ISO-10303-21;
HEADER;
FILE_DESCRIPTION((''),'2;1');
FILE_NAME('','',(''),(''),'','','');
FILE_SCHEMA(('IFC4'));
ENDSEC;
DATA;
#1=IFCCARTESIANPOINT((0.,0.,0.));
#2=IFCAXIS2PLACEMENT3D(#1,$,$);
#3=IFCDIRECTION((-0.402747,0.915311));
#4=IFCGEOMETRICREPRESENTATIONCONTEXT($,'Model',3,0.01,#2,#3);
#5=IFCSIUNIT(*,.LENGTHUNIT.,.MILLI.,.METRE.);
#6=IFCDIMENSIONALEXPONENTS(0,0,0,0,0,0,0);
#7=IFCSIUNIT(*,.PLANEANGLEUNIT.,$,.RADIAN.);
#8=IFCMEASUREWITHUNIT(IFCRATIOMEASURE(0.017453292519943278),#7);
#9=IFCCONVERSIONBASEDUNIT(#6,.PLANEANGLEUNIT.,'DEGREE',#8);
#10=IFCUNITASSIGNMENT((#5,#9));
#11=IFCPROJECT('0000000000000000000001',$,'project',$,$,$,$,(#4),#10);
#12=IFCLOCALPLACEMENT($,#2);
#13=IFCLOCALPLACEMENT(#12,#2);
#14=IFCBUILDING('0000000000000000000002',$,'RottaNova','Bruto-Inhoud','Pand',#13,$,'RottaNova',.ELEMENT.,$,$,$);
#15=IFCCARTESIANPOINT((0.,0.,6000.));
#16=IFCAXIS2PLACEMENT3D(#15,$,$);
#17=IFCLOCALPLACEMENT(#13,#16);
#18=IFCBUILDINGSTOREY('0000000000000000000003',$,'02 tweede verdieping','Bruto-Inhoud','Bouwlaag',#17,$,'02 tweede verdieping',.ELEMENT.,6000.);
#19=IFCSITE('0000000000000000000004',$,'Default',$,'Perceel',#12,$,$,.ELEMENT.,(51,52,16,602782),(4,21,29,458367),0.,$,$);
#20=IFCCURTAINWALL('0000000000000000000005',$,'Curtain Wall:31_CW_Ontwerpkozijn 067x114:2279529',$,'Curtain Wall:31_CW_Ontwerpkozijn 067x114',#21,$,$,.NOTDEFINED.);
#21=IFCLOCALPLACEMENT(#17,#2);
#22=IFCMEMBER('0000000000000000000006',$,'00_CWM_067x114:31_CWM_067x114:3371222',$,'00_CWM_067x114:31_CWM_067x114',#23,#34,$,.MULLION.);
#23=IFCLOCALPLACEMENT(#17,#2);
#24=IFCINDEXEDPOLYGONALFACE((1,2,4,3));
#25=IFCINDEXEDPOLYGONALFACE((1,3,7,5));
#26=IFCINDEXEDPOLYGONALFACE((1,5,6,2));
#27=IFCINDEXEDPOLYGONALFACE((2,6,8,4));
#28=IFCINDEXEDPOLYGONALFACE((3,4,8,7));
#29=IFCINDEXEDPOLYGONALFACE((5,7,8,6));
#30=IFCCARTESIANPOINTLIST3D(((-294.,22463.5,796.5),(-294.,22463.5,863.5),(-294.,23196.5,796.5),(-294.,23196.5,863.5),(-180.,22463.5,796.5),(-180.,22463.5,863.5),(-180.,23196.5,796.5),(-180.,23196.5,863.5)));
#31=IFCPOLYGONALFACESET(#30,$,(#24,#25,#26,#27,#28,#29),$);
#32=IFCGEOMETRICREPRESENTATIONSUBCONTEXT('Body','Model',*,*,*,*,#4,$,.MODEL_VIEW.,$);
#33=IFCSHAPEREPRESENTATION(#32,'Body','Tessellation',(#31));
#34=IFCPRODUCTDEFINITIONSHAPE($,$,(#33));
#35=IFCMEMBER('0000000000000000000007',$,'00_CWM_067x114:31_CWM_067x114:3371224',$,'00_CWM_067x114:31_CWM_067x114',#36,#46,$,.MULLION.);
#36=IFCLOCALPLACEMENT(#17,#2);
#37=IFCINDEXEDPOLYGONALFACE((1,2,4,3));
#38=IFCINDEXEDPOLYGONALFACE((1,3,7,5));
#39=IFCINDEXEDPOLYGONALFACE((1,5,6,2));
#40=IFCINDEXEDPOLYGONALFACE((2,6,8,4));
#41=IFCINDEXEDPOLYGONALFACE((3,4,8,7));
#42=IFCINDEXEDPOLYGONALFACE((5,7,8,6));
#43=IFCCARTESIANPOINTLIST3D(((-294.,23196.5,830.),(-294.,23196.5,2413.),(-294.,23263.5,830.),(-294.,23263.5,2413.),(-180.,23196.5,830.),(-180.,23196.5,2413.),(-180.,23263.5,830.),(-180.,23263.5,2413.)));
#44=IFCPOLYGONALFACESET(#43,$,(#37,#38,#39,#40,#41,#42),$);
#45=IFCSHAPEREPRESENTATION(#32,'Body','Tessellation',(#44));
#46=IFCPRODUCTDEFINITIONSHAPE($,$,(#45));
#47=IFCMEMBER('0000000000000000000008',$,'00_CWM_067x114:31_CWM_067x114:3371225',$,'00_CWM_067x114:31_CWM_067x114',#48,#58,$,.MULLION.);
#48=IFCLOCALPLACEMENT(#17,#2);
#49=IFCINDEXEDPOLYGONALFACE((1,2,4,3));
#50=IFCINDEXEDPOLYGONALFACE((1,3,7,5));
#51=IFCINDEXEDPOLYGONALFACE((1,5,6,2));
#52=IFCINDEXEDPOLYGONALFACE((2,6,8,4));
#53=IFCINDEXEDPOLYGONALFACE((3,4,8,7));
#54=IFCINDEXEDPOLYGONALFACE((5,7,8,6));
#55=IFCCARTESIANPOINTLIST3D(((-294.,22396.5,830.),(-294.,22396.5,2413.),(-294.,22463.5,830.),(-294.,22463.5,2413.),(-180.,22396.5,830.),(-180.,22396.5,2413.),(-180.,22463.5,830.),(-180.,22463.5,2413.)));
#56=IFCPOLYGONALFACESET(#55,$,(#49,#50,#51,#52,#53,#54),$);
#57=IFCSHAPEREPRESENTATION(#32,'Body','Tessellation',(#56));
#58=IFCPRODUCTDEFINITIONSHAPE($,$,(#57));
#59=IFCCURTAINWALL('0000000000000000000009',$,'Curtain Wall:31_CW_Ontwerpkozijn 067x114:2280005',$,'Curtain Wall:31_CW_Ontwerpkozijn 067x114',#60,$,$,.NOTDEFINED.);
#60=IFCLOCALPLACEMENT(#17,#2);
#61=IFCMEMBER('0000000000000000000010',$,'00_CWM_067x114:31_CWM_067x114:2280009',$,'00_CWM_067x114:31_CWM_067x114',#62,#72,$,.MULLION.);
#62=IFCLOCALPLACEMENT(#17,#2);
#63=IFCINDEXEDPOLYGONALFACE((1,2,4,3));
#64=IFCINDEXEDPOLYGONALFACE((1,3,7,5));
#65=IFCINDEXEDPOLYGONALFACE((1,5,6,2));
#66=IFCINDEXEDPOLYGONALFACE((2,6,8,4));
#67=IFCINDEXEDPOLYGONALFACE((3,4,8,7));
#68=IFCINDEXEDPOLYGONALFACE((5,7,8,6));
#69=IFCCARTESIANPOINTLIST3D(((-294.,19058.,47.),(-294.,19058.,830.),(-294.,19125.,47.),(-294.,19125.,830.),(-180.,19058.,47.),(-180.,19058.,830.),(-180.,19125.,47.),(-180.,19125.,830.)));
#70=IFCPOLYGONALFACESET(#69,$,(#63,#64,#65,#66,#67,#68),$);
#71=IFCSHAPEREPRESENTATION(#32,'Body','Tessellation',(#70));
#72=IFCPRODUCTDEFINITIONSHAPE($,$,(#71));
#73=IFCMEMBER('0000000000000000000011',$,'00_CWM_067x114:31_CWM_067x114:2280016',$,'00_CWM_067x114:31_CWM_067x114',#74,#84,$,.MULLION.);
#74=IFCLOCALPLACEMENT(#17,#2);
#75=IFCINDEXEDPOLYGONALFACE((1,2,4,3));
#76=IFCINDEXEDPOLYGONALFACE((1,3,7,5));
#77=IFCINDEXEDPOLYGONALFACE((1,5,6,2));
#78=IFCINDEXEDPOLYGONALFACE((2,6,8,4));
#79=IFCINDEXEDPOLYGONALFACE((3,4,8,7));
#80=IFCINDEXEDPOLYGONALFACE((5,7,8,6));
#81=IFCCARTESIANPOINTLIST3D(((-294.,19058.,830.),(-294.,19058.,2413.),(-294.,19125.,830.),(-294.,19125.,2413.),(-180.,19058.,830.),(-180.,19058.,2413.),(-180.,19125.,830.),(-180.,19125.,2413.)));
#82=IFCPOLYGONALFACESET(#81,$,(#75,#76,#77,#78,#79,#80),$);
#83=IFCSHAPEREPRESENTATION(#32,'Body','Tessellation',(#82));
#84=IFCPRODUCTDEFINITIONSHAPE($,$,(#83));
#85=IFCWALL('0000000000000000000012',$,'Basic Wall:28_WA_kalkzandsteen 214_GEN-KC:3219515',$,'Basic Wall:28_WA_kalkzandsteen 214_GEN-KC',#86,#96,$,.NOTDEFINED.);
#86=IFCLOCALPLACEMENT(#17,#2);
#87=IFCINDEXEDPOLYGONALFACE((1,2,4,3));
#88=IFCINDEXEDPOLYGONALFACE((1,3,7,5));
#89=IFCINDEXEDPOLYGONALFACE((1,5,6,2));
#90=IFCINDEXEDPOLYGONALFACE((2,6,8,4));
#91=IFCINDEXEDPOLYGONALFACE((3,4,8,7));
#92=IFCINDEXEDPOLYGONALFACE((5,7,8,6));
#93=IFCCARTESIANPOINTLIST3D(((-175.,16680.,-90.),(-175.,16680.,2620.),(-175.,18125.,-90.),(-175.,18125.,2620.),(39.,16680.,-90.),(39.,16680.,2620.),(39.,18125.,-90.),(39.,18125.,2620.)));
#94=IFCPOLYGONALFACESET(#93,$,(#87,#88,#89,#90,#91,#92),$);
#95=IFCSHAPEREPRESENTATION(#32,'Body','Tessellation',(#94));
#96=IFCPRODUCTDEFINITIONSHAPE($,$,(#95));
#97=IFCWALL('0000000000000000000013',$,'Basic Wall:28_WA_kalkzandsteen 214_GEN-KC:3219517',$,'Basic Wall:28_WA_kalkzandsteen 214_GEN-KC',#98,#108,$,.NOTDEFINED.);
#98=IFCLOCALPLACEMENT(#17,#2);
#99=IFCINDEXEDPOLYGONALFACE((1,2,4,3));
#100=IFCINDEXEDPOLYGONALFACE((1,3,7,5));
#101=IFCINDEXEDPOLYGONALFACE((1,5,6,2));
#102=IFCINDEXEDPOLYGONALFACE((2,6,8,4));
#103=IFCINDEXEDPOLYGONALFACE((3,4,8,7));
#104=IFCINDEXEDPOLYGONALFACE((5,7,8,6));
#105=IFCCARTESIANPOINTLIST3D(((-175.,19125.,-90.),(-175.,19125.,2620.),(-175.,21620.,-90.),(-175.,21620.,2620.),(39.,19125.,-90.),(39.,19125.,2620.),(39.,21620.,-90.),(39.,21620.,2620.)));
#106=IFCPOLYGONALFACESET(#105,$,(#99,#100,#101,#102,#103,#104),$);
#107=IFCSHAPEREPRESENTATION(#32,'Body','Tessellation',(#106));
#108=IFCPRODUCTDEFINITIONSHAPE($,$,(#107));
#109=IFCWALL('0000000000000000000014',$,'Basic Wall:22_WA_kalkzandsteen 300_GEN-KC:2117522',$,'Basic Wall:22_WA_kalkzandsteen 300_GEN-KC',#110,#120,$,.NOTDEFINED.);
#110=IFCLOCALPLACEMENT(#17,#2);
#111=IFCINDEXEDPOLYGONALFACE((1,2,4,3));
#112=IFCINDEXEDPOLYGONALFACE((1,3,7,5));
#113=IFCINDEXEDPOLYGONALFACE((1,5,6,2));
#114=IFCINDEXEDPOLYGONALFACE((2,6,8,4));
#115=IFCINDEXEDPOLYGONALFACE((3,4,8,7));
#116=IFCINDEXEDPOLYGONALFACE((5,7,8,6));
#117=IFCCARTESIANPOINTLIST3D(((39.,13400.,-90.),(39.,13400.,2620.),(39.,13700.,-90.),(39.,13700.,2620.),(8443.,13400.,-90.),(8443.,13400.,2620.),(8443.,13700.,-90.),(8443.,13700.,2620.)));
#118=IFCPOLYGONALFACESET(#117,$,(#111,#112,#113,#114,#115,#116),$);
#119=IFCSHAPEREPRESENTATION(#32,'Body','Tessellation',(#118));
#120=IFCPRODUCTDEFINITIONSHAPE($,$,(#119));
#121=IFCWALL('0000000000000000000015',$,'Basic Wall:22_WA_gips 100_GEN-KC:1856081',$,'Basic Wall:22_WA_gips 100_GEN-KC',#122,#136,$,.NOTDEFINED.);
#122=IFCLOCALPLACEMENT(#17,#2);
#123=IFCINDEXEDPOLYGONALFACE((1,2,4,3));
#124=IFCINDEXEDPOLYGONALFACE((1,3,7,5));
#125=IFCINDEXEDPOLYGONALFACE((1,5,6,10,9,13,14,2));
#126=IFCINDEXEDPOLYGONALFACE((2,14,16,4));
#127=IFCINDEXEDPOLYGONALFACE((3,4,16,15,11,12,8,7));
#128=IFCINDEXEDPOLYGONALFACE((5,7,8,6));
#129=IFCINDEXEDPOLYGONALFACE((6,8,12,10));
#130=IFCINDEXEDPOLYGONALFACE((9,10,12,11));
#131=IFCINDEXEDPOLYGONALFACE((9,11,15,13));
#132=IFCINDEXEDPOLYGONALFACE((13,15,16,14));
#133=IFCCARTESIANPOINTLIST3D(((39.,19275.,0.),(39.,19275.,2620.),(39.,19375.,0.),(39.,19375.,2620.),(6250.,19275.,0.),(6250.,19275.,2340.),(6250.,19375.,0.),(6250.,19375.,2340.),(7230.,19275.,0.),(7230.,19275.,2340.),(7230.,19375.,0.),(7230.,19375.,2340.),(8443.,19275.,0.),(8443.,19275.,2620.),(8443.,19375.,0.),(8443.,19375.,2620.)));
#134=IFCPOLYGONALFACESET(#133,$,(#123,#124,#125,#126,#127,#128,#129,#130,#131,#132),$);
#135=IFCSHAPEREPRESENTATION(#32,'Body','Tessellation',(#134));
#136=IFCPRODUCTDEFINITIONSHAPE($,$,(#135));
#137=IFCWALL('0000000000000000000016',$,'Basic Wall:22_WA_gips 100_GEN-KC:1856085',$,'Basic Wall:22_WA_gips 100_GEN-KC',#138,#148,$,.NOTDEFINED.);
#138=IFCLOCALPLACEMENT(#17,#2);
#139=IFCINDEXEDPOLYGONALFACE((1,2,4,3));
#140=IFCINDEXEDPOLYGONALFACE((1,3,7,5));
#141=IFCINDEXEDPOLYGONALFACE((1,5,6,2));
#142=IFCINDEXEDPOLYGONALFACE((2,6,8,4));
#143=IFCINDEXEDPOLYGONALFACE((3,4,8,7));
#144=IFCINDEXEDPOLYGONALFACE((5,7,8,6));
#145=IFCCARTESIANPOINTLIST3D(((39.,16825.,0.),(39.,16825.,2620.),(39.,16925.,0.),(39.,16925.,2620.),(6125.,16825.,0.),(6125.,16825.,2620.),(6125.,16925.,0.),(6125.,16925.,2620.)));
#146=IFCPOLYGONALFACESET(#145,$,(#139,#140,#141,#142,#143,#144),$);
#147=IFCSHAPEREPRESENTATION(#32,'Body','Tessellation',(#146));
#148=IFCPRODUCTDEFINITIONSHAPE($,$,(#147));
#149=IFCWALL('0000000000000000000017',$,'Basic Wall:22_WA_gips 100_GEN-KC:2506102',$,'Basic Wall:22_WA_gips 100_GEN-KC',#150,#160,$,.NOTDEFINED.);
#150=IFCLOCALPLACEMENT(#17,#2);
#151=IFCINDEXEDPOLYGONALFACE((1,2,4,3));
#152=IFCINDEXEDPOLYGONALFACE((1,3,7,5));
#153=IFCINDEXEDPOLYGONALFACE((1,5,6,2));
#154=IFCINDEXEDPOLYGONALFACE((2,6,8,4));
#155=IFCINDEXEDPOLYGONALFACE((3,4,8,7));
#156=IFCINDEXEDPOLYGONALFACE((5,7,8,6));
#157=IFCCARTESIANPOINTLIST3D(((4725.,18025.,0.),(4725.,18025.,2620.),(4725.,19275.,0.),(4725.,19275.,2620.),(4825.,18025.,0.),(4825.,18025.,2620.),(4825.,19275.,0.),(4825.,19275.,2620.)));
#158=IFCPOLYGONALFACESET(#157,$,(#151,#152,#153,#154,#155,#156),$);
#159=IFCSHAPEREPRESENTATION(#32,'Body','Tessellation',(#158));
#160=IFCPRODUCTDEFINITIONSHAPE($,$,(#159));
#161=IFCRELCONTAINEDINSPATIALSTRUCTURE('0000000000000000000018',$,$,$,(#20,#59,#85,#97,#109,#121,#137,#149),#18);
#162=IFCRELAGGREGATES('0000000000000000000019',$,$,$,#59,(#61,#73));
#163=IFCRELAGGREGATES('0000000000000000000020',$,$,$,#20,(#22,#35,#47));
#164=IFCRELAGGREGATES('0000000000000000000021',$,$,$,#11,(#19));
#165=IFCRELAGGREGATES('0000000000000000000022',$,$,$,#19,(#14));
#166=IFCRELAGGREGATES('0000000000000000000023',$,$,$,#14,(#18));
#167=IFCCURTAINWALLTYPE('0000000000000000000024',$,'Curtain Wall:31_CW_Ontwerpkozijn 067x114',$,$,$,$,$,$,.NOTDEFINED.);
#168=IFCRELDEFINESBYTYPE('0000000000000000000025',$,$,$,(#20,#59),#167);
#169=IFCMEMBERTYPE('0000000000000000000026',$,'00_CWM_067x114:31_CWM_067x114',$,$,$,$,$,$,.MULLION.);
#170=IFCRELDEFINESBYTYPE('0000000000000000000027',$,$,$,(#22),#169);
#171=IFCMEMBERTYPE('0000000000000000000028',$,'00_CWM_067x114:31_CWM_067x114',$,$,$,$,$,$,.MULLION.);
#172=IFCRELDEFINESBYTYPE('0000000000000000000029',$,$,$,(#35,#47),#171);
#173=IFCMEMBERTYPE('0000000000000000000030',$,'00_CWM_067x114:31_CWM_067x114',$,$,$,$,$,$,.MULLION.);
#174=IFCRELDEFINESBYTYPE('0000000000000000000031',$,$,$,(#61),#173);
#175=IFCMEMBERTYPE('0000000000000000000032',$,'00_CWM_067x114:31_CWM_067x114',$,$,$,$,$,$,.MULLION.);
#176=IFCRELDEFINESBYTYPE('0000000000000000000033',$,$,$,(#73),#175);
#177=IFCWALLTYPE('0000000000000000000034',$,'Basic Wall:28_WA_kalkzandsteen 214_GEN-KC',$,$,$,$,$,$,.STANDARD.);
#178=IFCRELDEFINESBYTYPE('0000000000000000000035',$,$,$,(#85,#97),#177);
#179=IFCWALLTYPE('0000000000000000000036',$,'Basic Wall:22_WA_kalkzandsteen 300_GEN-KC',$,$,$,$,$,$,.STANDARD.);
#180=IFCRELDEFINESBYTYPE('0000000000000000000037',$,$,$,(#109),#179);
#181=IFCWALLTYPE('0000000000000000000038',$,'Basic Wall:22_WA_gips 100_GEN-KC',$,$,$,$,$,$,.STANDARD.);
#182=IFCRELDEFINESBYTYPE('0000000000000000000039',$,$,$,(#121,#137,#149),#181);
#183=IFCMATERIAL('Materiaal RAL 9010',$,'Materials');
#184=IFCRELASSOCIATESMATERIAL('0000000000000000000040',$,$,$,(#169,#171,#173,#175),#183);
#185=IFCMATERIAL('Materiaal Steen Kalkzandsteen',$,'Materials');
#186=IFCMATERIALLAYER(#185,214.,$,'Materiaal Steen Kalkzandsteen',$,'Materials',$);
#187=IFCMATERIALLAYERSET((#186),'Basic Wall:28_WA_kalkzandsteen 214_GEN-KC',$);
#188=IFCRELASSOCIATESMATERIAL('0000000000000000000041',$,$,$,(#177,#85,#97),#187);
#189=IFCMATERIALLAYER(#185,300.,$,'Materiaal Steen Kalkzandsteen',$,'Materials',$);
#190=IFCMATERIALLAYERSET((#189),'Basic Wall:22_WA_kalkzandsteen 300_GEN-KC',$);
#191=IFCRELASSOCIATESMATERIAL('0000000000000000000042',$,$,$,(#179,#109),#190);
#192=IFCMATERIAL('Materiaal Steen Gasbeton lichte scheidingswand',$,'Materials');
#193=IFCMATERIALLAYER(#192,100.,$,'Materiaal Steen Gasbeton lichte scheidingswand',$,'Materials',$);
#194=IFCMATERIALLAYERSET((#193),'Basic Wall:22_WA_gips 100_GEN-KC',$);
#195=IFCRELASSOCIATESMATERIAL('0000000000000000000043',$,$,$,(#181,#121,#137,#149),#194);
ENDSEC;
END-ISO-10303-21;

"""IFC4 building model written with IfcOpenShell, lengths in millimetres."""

from ifc_helpers import new_model, entity, si_unit, converted_unit, direction, frame, frame_2d, origin, origin_2d_with_axis, place, context, subcontext, project, spatial, rectangle, extrude, source, transform, mapped, material, layer, layer_set, material_profile, profile_set, type_object, type_shapes, element, aggregate, save


model = new_model("IFC4")

# Units and contexts
model_context = context("Model", 3, precision=0.01, world=origin(), true_north=direction((-0.402747, 0.915311)))
body_context = subcontext(model_context, "Body", "Model", "MODEL_VIEW")
ifc_project = project(units=[si_unit("LENGTHUNIT", "METRE", prefix="MILLI"), converted_unit("PLANEANGLEUNIT", "DEGREE", entity("IfcRatioMeasure", 0.017453292519943278), si_unit("PLANEANGLEUNIT", "RADIAN"), dimensions=[0, 0, 0, 0, 0, 0, 0])], contexts=[model_context])

# Site, building, storey
site_placement = place(None, origin())
site = spatial("IfcSite", under=ifc_project, at=site_placement, Name="Default", ObjectType="Perceel", CompositionType="ELEMENT", RefLatitude=(51, 52, 16, 602782), RefLongitude=(4, 21, 29, 458367), RefElevation=0.0)
building_placement = place(site_placement, origin())
building = spatial("IfcBuilding", under=site, at=building_placement, Name="RottaNova", Description="Bruto-Inhoud", ObjectType="Pand", LongName="RottaNova", CompositionType="ELEMENT")
storey_placement = place(building_placement, frame((0.0, 0.0, 6000.0)))
storey = spatial("IfcBuildingStorey", under=building, at=storey_placement, Name="02 tweede verdieping", Description="Bruto-Inhoud", ObjectType="Bouwlaag", LongName="02 tweede verdieping", CompositionType="ELEMENT", Elevation=6000.0)

# Curtain walls, members
curtain_wall_type = type_object("IfcCurtainWallType", Name="Curtain Wall:31_CW_Ontwerpkozijn 067x114", PredefinedType="NOTDEFINED")
curtain_wall_1_placement = place(storey_placement, frame((0.0, 0.0, -6000.0)))
curtain_wall_1 = element("IfcCurtainWall", 1, at=curtain_wall_1_placement, inside=storey, type_object=curtain_wall_type, Name="Curtain Wall:31_CW_Ontwerpkozijn 067x114:2279529", ObjectType="Curtain Wall:31_CW_Ontwerpkozijn 067x114", PredefinedType="NOTDEFINED")
ifc_material_1 = material(Name="Materiaal RAL 9010", Category="Materials")
ifc_material_profile = material_profile(ifc_material_1, rectangle(XDim=114.0, YDim=67.0, at=origin_2d_with_axis()), Name="31_CWM_067x114")
ifc_profile_set = profile_set([ifc_material_profile], Name="31_CWM_067x114")
member_type_1 = type_object("IfcMemberType", Name="00_CWM_067x114:31_CWM_067x114", PredefinedType="MULLION", material=ifc_profile_set)
shared_shape_1 = source(origin(), body_context, "Body", "SweptSolid", [
    extrude(rectangle(XDim=114.0, YDim=67.0, at=origin_2d_with_axis()), frame((0.0, 57.0, -733.0), z_axis=(0.0, 0.0, 1.0), x_axis=(0.0, -1.0, 0.0)), (0.0, 0.0, 1.0), 733.0),
])
type_shapes(member_type_1, [shared_shape_1])
member_1_placement = place(curtain_wall_1_placement, frame((-180.0, 22463.5, 6830.0), z_axis=(0.0, -1.0, 0.0), x_axis=(0.0, 0.0, 1.0)))
member_1 = element("IfcMember", 2, at=member_1_placement, type_object=member_type_1, Name="00_CWM_067x114:31_CWM_067x114:3371222", ObjectType="00_CWM_067x114:31_CWM_067x114", PredefinedType="MULLION", context=body_context, shape_type="MappedRepresentation", body=[
    mapped(shared_shape_1, transform((0.0, 0.0, 0.0), scale=1.0)),
])
member_type_2 = type_object("IfcMemberType", Name="00_CWM_067x114:31_CWM_067x114", PredefinedType="MULLION", material=ifc_profile_set)
shared_shape_2 = source(origin(), body_context, "Body", "SweptSolid", [
    extrude(rectangle(XDim=114.0, YDim=67.0, at=origin_2d_with_axis()), frame((0.0, 57.0, -1583.0), z_axis=(0.0, 0.0, 1.0), x_axis=(0.0, -1.0, 0.0)), (0.0, 0.0, 1.0), 1583.0),
])
type_shapes(member_type_2, [shared_shape_2])
member_2_placement = place(curtain_wall_1_placement, frame((-180.0, 23230.0, 6830.0), z_axis=(0.0, 0.0, -1.0), x_axis=(0.0, -1.0, 0.0)))
member_2 = element("IfcMember", 3, at=member_2_placement, type_object=member_type_2, Name="00_CWM_067x114:31_CWM_067x114:3371224", ObjectType="00_CWM_067x114:31_CWM_067x114", PredefinedType="MULLION", context=body_context, shape_type="MappedRepresentation", body=[
    mapped(shared_shape_2, transform((0.0, 0.0, 0.0), scale=1.0)),
])
member_3_placement = place(curtain_wall_1_placement, frame((-180.0, 22430.0, 6830.0), z_axis=(0.0, 0.0, -1.0), x_axis=(0.0, -1.0, 0.0)))
member_3 = element("IfcMember", 4, at=member_3_placement, type_object=member_type_2, Name="00_CWM_067x114:31_CWM_067x114:3371225", ObjectType="00_CWM_067x114:31_CWM_067x114", PredefinedType="MULLION", context=body_context, shape_type="MappedRepresentation", body=[
    mapped(shared_shape_2, transform((0.0, 0.0, 0.0), scale=1.0)),
])
curtain_wall_2_placement = place(storey_placement, frame((0.0, 0.0, -6000.0)))
curtain_wall_2 = element("IfcCurtainWall", 5, at=curtain_wall_2_placement, inside=storey, type_object=curtain_wall_type, Name="Curtain Wall:31_CW_Ontwerpkozijn 067x114:2280005", ObjectType="Curtain Wall:31_CW_Ontwerpkozijn 067x114", PredefinedType="NOTDEFINED")
member_type_3 = type_object("IfcMemberType", Name="00_CWM_067x114:31_CWM_067x114", PredefinedType="MULLION", material=ifc_profile_set)
shared_shape_3 = source(origin(), body_context, "Body", "SweptSolid", [
    extrude(rectangle(XDim=114.0, YDim=67.0, at=frame_2d((0.0, 0.0), x_axis=(1.0, 0.0))), frame((-33.5, -57.0, -783.0), z_axis=(0.0, 0.0, 1.0), x_axis=(0.0, -1.0, 0.0)), (0.0, 0.0, 1.0), 783.0),
])
type_shapes(member_type_3, [shared_shape_3])
member_4_placement = place(curtain_wall_2_placement, frame((-180.0, 19125.0, 6047.0), z_axis=(0.0, 0.0, -1.0), x_axis=(0.0, 1.0, 0.0)))
member_4 = element("IfcMember", 6, at=member_4_placement, type_object=member_type_3, Name="00_CWM_067x114:31_CWM_067x114:2280009", ObjectType="00_CWM_067x114:31_CWM_067x114", PredefinedType="MULLION", context=body_context, shape_type="MappedRepresentation", body=[
    mapped(shared_shape_3, transform((0.0, 0.0, 0.0), scale=1.0)),
])
member_type_4 = type_object("IfcMemberType", Name="00_CWM_067x114:31_CWM_067x114", PredefinedType="MULLION", material=ifc_profile_set)
shared_shape_4 = source(origin(), body_context, "Body", "SweptSolid", [
    extrude(rectangle(XDim=114.0, YDim=67.0, at=origin_2d_with_axis()), frame((-33.5, -57.0, -1583.0), z_axis=(0.0, 0.0, 1.0), x_axis=(0.0, -1.0, 0.0)), (0.0, 0.0, 1.0), 1583.0),
])
type_shapes(member_type_4, [shared_shape_4])
member_5_placement = place(curtain_wall_2_placement, frame((-180.0, 19125.0, 6830.0), z_axis=(0.0, 0.0, -1.0), x_axis=(0.0, 1.0, 0.0)))
member_5 = element("IfcMember", 7, at=member_5_placement, type_object=member_type_4, Name="00_CWM_067x114:31_CWM_067x114:2280016", ObjectType="00_CWM_067x114:31_CWM_067x114", PredefinedType="MULLION", context=body_context, shape_type="MappedRepresentation", body=[
    mapped(shared_shape_4, transform((0.0, 0.0, 0.0), scale=1.0)),
])
aggregate(curtain_wall_2, [member_4, member_5])

# Walls
ifc_material_2 = material(Name="Materiaal Steen Kalkzandsteen", Category="Materials")
ifc_layer_1 = layer(ifc_material_2, 214.0, Name="Materiaal Steen Kalkzandsteen", Category="Materials")
ifc_layer_set_1 = layer_set([ifc_layer_1], Name="Basic Wall:28_WA_kalkzandsteen 214_GEN-KC")
wall_type_1 = type_object("IfcWallType", Name="Basic Wall:28_WA_kalkzandsteen 214_GEN-KC", PredefinedType="STANDARD", material=ifc_layer_set_1)
wall_1_placement = place(storey_placement, frame((-68.0, 16680.0, -90.0), z_axis=(0.0, 0.0, 1.0), x_axis=(0.0, 1.0, 0.0)))
element("IfcWall", 8, at=wall_1_placement, inside=storey, type_object=wall_type_1, material=ifc_layer_set_1, Name="Basic Wall:28_WA_kalkzandsteen 214_GEN-KC:3219515", ObjectType="Basic Wall:28_WA_kalkzandsteen 214_GEN-KC", PredefinedType="NOTDEFINED", context=body_context, shape_type="SweptSolid", body=[
    extrude(rectangle(XDim=1445.0, YDim=214.0, at=frame_2d((722.5, 0.0), x_axis=(-1.0, 0.0))), origin(), (0.0, 0.0, 1.0), 2710.0),
])
wall_2_placement = place(storey_placement, frame((-68.0, 19125.0, -90.0), z_axis=(0.0, 0.0, 1.0), x_axis=(0.0, 1.0, 0.0)))
element("IfcWall", 9, at=wall_2_placement, inside=storey, type_object=wall_type_1, material=ifc_layer_set_1, Name="Basic Wall:28_WA_kalkzandsteen 214_GEN-KC:3219517", ObjectType="Basic Wall:28_WA_kalkzandsteen 214_GEN-KC", PredefinedType="NOTDEFINED", context=body_context, shape_type="SweptSolid", body=[
    extrude(rectangle(XDim=2495.0, YDim=214.0, at=frame_2d((1247.5, 0.0), x_axis=(-1.0, 0.0))), origin(), (0.0, 0.0, 1.0), 2710.0),
])
ifc_layer_2 = layer(ifc_material_2, 300.0, Name="Materiaal Steen Kalkzandsteen", Category="Materials")
ifc_layer_set_2 = layer_set([ifc_layer_2], Name="Basic Wall:22_WA_kalkzandsteen 300_GEN-KC")
wall_type_2 = type_object("IfcWallType", Name="Basic Wall:22_WA_kalkzandsteen 300_GEN-KC", PredefinedType="STANDARD", material=ifc_layer_set_2)
wall_3_placement = place(storey_placement, frame((39.0, 13550.0, -90.0)))
element("IfcWall", 10, at=wall_3_placement, inside=storey, type_object=wall_type_2, material=ifc_layer_set_2, Name="Basic Wall:22_WA_kalkzandsteen 300_GEN-KC:2117522", ObjectType="Basic Wall:22_WA_kalkzandsteen 300_GEN-KC", PredefinedType="NOTDEFINED", context=body_context, shape_type="SweptSolid", body=[
    extrude(rectangle(XDim=8404.0, YDim=300.0, at=frame_2d((4202.0, 0.0), x_axis=(-1.0, 0.0))), origin(), (0.0, 0.0, 1.0), 2710.0),
])

# Wall, opening
ifc_material_3 = material(Name="Materiaal Steen Gasbeton lichte scheidingswand", Category="Materials")
ifc_layer_3 = layer(ifc_material_3, 100.0, Name="Materiaal Steen Gasbeton lichte scheidingswand", Category="Materials")
ifc_layer_set_3 = layer_set([ifc_layer_3], Name="Basic Wall:22_WA_gips 100_GEN-KC")
wall_type_3 = type_object("IfcWallType", Name="Basic Wall:22_WA_gips 100_GEN-KC", PredefinedType="STANDARD", material=ifc_layer_set_3)
wall_4_placement = place(storey_placement, frame((39.0, 19325.0, 0.0)))
wall_4 = element("IfcWall", 11, at=wall_4_placement, inside=storey, type_object=wall_type_3, material=ifc_layer_set_3, Name="Basic Wall:22_WA_gips 100_GEN-KC:1856081", ObjectType="Basic Wall:22_WA_gips 100_GEN-KC", PredefinedType="NOTDEFINED", context=body_context, shape_type="SweptSolid", body=[
    extrude(rectangle(XDim=8404.0, YDim=100.0, at=frame_2d((4202.0, 0.0), x_axis=(-1.0, 0.0))), origin(), (0.0, 0.0, 1.0), 2620.0),
])
opening_placement = place(wall_4_placement, frame((6211.0, -50.0, -90.0)))
element("IfcOpeningElement", 12, at=opening_placement, cuts=wall_4, PredefinedType="OPENING", context=body_context, shape_type="SweptSolid", body=[
    extrude(rectangle(XDim=2430.0, YDim=980.0, at=frame_2d((1215.0, 490.0), x_axis=(1.0, 0.0))), frame((0.0, 0.0, 0.0), z_axis=(0.0, 1.0, 0.0), x_axis=(0.0, 0.0, 1.0)), (0.0, 0.0, 1.0), 100.0),
])

# Walls
wall_5_placement = place(storey_placement, frame((39.0, 16875.0, 0.0)))
element("IfcWall", 13, at=wall_5_placement, inside=storey, type_object=wall_type_3, material=ifc_layer_set_3, Name="Basic Wall:22_WA_gips 100_GEN-KC:1856085", ObjectType="Basic Wall:22_WA_gips 100_GEN-KC", PredefinedType="NOTDEFINED", context=body_context, shape_type="SweptSolid", body=[
    extrude(rectangle(XDim=6086.0, YDim=100.0, at=frame_2d((3043.0, 0.0), x_axis=(-1.0, 0.0))), origin(), (0.0, 0.0, 1.0), 2620.0),
])
wall_6_placement = place(storey_placement, frame((4775.0, 19275.0, 0.0), z_axis=(0.0, 0.0, 1.0), x_axis=(0.0, -1.0, 0.0)))
element("IfcWall", 14, at=wall_6_placement, inside=storey, type_object=wall_type_3, material=ifc_layer_set_3, Name="Basic Wall:22_WA_gips 100_GEN-KC:2506102", ObjectType="Basic Wall:22_WA_gips 100_GEN-KC", PredefinedType="NOTDEFINED", context=body_context, shape_type="SweptSolid", body=[
    extrude(rectangle(XDim=1250.0, YDim=100.0, at=frame_2d((625.0, 0.0), x_axis=(-1.0, 0.0))), origin(), (0.0, 0.0, 1.0), 2620.0),
])

aggregate(curtain_wall_1, [member_1, member_2, member_3])

save(model, "model.ifc")
